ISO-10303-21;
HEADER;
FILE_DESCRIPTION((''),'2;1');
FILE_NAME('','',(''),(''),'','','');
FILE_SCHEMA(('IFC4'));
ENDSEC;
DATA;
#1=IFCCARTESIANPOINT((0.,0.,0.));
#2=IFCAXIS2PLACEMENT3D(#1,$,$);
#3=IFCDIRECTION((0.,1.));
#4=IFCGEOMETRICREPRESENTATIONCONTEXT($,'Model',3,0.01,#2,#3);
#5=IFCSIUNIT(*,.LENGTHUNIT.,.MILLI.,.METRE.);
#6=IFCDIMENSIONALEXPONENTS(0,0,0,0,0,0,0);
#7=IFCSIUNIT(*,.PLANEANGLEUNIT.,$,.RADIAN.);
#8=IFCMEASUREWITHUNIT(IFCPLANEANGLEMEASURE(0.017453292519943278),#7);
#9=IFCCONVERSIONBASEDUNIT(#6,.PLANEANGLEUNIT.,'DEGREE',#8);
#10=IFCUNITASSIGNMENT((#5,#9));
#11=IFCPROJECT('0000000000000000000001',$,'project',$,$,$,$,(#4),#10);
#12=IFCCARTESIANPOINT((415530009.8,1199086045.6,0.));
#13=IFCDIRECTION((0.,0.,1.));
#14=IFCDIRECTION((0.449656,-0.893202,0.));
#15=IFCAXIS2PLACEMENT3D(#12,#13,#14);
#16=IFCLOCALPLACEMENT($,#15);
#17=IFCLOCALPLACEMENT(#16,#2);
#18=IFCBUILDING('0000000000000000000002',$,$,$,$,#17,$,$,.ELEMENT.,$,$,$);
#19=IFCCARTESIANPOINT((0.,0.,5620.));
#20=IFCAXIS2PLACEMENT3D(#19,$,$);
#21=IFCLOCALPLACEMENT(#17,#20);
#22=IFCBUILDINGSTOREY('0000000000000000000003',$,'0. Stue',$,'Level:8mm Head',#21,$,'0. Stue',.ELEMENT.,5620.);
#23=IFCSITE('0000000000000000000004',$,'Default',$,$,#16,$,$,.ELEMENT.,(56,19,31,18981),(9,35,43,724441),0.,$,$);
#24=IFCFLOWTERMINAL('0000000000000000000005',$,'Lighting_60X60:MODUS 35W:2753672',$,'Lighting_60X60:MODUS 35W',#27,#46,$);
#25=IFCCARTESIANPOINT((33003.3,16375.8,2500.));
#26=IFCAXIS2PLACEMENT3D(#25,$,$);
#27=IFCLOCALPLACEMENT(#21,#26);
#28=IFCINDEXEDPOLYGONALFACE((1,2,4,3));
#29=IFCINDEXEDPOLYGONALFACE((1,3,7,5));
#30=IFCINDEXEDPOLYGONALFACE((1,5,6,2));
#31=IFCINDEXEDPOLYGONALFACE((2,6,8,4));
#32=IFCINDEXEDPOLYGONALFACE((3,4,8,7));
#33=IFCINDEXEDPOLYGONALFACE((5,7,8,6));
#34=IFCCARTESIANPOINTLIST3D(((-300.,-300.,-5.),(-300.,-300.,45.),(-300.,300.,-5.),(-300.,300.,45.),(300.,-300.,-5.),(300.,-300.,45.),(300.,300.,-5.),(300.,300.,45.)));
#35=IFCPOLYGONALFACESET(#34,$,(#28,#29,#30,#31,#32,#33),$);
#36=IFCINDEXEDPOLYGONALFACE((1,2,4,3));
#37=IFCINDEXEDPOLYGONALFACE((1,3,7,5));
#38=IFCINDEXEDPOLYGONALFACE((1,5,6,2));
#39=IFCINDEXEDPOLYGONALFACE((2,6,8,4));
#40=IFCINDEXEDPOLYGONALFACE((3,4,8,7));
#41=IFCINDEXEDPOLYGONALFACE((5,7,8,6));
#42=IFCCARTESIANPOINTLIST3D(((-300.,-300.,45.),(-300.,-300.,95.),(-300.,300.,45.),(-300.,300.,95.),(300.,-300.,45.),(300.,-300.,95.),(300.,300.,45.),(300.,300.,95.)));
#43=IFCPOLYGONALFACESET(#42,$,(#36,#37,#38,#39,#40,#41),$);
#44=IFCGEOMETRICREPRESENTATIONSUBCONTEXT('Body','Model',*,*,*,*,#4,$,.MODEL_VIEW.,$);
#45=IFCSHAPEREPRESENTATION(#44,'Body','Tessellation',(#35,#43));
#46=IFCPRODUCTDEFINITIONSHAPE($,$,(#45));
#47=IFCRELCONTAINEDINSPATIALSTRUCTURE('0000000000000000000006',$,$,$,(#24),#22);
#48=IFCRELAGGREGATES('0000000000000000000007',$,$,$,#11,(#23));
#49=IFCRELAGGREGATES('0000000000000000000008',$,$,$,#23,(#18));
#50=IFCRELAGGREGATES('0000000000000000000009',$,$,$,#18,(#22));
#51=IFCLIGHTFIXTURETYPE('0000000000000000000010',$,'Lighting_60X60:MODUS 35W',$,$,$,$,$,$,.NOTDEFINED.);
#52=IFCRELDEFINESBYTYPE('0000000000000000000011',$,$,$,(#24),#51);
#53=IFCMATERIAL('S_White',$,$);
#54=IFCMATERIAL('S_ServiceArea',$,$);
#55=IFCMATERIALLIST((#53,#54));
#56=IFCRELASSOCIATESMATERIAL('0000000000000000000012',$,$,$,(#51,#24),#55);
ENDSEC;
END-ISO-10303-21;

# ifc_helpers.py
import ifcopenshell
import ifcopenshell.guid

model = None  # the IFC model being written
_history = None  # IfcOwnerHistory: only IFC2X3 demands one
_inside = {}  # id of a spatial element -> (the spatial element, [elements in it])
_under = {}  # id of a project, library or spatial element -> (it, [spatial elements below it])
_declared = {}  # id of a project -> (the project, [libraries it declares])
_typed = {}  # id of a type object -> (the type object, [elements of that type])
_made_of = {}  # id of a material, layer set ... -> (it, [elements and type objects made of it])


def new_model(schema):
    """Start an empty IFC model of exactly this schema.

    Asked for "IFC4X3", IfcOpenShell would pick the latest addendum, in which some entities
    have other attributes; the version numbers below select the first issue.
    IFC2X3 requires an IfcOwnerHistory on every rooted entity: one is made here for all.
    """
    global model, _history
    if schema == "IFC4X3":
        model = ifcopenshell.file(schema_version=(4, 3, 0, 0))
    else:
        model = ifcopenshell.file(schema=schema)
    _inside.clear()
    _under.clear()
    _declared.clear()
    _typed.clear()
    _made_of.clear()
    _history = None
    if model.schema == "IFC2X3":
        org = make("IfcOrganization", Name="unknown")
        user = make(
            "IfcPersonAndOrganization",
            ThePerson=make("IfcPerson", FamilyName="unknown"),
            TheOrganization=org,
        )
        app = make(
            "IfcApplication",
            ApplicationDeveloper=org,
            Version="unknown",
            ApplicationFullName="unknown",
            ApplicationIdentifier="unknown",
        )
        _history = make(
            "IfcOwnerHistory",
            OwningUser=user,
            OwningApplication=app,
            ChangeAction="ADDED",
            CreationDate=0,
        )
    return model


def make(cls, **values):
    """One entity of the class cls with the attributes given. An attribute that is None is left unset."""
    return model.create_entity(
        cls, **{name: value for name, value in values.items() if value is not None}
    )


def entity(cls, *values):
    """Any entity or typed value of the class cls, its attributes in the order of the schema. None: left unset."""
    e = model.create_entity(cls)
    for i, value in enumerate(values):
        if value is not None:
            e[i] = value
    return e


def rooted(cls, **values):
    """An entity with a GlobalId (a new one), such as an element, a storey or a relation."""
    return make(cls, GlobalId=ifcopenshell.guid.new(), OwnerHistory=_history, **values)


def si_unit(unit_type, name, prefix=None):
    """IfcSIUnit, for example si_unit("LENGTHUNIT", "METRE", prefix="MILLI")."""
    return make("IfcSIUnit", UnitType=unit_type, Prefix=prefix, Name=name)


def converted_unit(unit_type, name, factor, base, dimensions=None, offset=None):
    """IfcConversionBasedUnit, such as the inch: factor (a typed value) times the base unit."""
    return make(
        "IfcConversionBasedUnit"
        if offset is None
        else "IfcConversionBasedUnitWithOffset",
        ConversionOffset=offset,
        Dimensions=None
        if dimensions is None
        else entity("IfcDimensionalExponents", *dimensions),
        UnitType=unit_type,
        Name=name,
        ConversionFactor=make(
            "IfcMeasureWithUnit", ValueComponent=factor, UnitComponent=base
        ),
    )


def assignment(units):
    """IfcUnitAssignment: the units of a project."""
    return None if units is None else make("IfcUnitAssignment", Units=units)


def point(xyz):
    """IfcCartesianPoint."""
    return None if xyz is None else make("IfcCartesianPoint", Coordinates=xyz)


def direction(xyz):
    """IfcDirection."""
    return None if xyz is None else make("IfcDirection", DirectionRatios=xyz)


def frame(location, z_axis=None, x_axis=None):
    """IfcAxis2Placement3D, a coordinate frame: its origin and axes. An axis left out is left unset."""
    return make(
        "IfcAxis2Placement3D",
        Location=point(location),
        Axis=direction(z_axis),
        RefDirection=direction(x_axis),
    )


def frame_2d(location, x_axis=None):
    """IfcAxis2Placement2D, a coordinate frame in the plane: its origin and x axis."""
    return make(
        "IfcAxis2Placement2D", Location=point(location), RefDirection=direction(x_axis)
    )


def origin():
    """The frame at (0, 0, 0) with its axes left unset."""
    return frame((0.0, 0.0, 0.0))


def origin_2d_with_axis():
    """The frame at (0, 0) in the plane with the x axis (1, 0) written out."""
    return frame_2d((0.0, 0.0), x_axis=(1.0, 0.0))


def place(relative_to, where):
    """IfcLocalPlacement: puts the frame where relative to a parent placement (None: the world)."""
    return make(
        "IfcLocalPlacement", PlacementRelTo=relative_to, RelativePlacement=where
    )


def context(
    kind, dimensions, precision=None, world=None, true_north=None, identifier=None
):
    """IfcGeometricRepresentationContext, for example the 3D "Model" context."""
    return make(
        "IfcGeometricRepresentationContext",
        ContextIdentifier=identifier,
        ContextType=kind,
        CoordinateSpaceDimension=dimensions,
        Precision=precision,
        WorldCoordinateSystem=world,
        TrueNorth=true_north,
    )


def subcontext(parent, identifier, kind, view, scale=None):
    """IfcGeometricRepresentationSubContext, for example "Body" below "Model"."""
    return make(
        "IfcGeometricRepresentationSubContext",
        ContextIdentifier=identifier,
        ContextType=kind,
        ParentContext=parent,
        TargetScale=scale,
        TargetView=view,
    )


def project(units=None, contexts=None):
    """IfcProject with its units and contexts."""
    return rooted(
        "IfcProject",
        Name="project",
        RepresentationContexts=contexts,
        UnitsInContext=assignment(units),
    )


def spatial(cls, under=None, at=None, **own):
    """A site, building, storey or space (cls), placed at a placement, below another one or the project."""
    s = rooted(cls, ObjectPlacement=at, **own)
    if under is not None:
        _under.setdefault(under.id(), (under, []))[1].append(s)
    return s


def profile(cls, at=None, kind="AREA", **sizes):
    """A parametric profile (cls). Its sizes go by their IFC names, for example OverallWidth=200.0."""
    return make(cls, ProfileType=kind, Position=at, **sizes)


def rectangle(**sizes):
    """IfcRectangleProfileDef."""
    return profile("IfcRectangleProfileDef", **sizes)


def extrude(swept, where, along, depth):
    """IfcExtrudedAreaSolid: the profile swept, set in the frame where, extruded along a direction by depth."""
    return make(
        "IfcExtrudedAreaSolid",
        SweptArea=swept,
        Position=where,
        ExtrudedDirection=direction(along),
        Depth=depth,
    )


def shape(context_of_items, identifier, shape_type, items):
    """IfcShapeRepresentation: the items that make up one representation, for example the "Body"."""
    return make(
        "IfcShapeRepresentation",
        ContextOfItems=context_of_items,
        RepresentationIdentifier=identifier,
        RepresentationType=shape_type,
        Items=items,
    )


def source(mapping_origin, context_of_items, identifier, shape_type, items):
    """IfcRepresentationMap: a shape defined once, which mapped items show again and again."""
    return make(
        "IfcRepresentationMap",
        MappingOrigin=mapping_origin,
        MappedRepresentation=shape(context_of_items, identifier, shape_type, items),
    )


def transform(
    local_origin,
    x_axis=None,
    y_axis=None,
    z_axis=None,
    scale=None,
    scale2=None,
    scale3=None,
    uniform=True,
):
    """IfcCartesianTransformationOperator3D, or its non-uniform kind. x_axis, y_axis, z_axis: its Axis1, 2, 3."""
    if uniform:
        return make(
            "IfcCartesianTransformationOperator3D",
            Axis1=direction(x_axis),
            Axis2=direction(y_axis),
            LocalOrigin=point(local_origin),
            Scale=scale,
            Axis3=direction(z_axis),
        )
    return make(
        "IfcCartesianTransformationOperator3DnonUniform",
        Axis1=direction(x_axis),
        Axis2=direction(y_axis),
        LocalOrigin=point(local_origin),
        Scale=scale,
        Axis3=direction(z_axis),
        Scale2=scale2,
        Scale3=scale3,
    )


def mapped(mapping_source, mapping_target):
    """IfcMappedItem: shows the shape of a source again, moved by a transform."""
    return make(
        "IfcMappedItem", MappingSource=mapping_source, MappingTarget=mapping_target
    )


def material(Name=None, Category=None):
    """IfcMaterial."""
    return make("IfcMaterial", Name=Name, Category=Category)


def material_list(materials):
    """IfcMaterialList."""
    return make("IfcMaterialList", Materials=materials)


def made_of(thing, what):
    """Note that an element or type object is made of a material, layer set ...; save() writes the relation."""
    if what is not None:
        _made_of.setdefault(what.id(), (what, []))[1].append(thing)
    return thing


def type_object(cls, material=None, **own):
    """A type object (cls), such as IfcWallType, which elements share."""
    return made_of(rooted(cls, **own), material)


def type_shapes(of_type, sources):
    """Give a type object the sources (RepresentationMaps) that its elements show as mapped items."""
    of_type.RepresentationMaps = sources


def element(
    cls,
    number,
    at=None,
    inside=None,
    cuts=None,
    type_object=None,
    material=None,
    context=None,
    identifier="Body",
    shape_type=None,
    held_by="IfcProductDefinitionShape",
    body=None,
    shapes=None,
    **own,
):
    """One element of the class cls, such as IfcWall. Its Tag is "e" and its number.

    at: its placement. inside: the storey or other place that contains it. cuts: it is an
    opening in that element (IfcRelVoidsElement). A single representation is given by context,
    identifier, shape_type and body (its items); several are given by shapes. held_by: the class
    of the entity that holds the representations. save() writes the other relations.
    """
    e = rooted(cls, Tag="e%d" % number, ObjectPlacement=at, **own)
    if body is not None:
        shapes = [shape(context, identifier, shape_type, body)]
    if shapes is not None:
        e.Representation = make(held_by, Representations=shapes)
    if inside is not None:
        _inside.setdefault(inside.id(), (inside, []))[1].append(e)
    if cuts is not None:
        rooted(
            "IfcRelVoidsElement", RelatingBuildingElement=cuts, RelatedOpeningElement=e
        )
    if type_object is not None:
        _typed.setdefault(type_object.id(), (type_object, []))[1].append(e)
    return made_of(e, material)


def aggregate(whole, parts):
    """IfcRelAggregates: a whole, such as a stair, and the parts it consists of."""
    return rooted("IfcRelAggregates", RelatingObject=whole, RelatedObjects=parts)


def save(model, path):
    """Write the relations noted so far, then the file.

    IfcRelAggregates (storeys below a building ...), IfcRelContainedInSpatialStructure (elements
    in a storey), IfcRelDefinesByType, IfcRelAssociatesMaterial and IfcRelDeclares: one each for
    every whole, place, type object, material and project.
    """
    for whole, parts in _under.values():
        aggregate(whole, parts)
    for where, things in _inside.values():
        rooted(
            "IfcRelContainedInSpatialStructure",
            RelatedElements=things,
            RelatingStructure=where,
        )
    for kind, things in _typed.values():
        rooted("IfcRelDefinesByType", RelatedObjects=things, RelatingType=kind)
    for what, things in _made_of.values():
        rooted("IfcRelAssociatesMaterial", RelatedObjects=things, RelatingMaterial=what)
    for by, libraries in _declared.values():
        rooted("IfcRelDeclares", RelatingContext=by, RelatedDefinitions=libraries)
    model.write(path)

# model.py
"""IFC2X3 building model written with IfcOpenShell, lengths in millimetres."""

from ifc_helpers import new_model, entity, si_unit, converted_unit, direction, frame, frame_2d, origin, origin_2d_with_axis, place, context, subcontext, project, spatial, rectangle, extrude, source, transform, mapped, material, material_list, type_object, type_shapes, element, save


model = new_model("IFC2X3")

# Units and contexts
model_context = context("Model", 3, precision=0.01, world=origin(), true_north=direction((0.0, 1.0)))
body_context = subcontext(model_context, "Body", "Model", "MODEL_VIEW")
ifc_project = project(units=[si_unit("LENGTHUNIT", "METRE", prefix="MILLI"), converted_unit("PLANEANGLEUNIT", "DEGREE", entity("IfcPlaneAngleMeasure", 0.017453292519943278), si_unit("PLANEANGLEUNIT", "RADIAN"), dimensions=[0, 0, 0, 0, 0, 0, 0])], contexts=[model_context])

# Site, building, storey
site_placement = place(None, frame((415530009.8, 1199086045.6, 0.0), z_axis=(0.0, 0.0, 1.0), x_axis=(0.449656, -0.893202, 0.0)))
site = spatial("IfcSite", under=ifc_project, at=site_placement, Name="Default", CompositionType="ELEMENT", RefLatitude=(56, 19, 31, 18981), RefLongitude=(9, 35, 43, 724441), RefElevation=0.0)
building_placement = place(site_placement, origin())
building = spatial("IfcBuilding", under=site, at=building_placement, CompositionType="ELEMENT")
storey_placement = place(building_placement, frame((0.0, 0.0, 5620.0)))
storey = spatial("IfcBuildingStorey", under=building, at=storey_placement, Name="0. Stue", ObjectType="Level:8mm Head", LongName="0. Stue", CompositionType="ELEMENT", Elevation=5620.0)

# Flow terminal
ifc_material_1 = material(Name="S_White")
ifc_material_2 = material(Name="S_ServiceArea")
ifc_material_list = material_list([ifc_material_1, ifc_material_2])
light_fixture_type_1 = type_object("IfcLightFixtureType", Name="Lighting_60X60:MODUS 35W", PredefinedType="NOTDEFINED", material=ifc_material_list)
shared_shape_1 = source(origin(), body_context, "Body", "SweptSolid", [
    extrude(rectangle(XDim=600.0, YDim=600.0, at=origin_2d_with_axis()), frame((0.0, 0.0, -5.0), z_axis=(0.0, 0.0, 1.0), x_axis=(-1.0, 0.0, 0.0)), (0.0, 0.0, 1.0), 50.0),
    extrude(rectangle(XDim=600.0, YDim=600.0, at=frame_2d((0.0, 0.0), x_axis=(1.0, 0.0))), frame((0.0, 0.0, 45.0), z_axis=(0.0, 0.0, 1.0), x_axis=(-1.0, 0.0, 0.0)), (0.0, 0.0, 1.0), 50.0),
])
type_shapes(light_fixture_type_1, [shared_shape_1])
flow_terminal_1_placement = place(storey_placement, frame((33003.3, 16375.8, 2500.0)))
element("IfcFlowTerminal", 1, at=flow_terminal_1_placement, inside=storey, type_object=light_fixture_type_1, material=ifc_material_list, Name="Lighting_60X60:MODUS 35W:2753672", ObjectType="Lighting_60X60:MODUS 35W", context=body_context, shape_type="MappedRepresentation", body=[
    mapped(shared_shape_1, transform((0.0, 0.0, 0.0), scale=1.0)),
])

save(model, "model.ifc")
